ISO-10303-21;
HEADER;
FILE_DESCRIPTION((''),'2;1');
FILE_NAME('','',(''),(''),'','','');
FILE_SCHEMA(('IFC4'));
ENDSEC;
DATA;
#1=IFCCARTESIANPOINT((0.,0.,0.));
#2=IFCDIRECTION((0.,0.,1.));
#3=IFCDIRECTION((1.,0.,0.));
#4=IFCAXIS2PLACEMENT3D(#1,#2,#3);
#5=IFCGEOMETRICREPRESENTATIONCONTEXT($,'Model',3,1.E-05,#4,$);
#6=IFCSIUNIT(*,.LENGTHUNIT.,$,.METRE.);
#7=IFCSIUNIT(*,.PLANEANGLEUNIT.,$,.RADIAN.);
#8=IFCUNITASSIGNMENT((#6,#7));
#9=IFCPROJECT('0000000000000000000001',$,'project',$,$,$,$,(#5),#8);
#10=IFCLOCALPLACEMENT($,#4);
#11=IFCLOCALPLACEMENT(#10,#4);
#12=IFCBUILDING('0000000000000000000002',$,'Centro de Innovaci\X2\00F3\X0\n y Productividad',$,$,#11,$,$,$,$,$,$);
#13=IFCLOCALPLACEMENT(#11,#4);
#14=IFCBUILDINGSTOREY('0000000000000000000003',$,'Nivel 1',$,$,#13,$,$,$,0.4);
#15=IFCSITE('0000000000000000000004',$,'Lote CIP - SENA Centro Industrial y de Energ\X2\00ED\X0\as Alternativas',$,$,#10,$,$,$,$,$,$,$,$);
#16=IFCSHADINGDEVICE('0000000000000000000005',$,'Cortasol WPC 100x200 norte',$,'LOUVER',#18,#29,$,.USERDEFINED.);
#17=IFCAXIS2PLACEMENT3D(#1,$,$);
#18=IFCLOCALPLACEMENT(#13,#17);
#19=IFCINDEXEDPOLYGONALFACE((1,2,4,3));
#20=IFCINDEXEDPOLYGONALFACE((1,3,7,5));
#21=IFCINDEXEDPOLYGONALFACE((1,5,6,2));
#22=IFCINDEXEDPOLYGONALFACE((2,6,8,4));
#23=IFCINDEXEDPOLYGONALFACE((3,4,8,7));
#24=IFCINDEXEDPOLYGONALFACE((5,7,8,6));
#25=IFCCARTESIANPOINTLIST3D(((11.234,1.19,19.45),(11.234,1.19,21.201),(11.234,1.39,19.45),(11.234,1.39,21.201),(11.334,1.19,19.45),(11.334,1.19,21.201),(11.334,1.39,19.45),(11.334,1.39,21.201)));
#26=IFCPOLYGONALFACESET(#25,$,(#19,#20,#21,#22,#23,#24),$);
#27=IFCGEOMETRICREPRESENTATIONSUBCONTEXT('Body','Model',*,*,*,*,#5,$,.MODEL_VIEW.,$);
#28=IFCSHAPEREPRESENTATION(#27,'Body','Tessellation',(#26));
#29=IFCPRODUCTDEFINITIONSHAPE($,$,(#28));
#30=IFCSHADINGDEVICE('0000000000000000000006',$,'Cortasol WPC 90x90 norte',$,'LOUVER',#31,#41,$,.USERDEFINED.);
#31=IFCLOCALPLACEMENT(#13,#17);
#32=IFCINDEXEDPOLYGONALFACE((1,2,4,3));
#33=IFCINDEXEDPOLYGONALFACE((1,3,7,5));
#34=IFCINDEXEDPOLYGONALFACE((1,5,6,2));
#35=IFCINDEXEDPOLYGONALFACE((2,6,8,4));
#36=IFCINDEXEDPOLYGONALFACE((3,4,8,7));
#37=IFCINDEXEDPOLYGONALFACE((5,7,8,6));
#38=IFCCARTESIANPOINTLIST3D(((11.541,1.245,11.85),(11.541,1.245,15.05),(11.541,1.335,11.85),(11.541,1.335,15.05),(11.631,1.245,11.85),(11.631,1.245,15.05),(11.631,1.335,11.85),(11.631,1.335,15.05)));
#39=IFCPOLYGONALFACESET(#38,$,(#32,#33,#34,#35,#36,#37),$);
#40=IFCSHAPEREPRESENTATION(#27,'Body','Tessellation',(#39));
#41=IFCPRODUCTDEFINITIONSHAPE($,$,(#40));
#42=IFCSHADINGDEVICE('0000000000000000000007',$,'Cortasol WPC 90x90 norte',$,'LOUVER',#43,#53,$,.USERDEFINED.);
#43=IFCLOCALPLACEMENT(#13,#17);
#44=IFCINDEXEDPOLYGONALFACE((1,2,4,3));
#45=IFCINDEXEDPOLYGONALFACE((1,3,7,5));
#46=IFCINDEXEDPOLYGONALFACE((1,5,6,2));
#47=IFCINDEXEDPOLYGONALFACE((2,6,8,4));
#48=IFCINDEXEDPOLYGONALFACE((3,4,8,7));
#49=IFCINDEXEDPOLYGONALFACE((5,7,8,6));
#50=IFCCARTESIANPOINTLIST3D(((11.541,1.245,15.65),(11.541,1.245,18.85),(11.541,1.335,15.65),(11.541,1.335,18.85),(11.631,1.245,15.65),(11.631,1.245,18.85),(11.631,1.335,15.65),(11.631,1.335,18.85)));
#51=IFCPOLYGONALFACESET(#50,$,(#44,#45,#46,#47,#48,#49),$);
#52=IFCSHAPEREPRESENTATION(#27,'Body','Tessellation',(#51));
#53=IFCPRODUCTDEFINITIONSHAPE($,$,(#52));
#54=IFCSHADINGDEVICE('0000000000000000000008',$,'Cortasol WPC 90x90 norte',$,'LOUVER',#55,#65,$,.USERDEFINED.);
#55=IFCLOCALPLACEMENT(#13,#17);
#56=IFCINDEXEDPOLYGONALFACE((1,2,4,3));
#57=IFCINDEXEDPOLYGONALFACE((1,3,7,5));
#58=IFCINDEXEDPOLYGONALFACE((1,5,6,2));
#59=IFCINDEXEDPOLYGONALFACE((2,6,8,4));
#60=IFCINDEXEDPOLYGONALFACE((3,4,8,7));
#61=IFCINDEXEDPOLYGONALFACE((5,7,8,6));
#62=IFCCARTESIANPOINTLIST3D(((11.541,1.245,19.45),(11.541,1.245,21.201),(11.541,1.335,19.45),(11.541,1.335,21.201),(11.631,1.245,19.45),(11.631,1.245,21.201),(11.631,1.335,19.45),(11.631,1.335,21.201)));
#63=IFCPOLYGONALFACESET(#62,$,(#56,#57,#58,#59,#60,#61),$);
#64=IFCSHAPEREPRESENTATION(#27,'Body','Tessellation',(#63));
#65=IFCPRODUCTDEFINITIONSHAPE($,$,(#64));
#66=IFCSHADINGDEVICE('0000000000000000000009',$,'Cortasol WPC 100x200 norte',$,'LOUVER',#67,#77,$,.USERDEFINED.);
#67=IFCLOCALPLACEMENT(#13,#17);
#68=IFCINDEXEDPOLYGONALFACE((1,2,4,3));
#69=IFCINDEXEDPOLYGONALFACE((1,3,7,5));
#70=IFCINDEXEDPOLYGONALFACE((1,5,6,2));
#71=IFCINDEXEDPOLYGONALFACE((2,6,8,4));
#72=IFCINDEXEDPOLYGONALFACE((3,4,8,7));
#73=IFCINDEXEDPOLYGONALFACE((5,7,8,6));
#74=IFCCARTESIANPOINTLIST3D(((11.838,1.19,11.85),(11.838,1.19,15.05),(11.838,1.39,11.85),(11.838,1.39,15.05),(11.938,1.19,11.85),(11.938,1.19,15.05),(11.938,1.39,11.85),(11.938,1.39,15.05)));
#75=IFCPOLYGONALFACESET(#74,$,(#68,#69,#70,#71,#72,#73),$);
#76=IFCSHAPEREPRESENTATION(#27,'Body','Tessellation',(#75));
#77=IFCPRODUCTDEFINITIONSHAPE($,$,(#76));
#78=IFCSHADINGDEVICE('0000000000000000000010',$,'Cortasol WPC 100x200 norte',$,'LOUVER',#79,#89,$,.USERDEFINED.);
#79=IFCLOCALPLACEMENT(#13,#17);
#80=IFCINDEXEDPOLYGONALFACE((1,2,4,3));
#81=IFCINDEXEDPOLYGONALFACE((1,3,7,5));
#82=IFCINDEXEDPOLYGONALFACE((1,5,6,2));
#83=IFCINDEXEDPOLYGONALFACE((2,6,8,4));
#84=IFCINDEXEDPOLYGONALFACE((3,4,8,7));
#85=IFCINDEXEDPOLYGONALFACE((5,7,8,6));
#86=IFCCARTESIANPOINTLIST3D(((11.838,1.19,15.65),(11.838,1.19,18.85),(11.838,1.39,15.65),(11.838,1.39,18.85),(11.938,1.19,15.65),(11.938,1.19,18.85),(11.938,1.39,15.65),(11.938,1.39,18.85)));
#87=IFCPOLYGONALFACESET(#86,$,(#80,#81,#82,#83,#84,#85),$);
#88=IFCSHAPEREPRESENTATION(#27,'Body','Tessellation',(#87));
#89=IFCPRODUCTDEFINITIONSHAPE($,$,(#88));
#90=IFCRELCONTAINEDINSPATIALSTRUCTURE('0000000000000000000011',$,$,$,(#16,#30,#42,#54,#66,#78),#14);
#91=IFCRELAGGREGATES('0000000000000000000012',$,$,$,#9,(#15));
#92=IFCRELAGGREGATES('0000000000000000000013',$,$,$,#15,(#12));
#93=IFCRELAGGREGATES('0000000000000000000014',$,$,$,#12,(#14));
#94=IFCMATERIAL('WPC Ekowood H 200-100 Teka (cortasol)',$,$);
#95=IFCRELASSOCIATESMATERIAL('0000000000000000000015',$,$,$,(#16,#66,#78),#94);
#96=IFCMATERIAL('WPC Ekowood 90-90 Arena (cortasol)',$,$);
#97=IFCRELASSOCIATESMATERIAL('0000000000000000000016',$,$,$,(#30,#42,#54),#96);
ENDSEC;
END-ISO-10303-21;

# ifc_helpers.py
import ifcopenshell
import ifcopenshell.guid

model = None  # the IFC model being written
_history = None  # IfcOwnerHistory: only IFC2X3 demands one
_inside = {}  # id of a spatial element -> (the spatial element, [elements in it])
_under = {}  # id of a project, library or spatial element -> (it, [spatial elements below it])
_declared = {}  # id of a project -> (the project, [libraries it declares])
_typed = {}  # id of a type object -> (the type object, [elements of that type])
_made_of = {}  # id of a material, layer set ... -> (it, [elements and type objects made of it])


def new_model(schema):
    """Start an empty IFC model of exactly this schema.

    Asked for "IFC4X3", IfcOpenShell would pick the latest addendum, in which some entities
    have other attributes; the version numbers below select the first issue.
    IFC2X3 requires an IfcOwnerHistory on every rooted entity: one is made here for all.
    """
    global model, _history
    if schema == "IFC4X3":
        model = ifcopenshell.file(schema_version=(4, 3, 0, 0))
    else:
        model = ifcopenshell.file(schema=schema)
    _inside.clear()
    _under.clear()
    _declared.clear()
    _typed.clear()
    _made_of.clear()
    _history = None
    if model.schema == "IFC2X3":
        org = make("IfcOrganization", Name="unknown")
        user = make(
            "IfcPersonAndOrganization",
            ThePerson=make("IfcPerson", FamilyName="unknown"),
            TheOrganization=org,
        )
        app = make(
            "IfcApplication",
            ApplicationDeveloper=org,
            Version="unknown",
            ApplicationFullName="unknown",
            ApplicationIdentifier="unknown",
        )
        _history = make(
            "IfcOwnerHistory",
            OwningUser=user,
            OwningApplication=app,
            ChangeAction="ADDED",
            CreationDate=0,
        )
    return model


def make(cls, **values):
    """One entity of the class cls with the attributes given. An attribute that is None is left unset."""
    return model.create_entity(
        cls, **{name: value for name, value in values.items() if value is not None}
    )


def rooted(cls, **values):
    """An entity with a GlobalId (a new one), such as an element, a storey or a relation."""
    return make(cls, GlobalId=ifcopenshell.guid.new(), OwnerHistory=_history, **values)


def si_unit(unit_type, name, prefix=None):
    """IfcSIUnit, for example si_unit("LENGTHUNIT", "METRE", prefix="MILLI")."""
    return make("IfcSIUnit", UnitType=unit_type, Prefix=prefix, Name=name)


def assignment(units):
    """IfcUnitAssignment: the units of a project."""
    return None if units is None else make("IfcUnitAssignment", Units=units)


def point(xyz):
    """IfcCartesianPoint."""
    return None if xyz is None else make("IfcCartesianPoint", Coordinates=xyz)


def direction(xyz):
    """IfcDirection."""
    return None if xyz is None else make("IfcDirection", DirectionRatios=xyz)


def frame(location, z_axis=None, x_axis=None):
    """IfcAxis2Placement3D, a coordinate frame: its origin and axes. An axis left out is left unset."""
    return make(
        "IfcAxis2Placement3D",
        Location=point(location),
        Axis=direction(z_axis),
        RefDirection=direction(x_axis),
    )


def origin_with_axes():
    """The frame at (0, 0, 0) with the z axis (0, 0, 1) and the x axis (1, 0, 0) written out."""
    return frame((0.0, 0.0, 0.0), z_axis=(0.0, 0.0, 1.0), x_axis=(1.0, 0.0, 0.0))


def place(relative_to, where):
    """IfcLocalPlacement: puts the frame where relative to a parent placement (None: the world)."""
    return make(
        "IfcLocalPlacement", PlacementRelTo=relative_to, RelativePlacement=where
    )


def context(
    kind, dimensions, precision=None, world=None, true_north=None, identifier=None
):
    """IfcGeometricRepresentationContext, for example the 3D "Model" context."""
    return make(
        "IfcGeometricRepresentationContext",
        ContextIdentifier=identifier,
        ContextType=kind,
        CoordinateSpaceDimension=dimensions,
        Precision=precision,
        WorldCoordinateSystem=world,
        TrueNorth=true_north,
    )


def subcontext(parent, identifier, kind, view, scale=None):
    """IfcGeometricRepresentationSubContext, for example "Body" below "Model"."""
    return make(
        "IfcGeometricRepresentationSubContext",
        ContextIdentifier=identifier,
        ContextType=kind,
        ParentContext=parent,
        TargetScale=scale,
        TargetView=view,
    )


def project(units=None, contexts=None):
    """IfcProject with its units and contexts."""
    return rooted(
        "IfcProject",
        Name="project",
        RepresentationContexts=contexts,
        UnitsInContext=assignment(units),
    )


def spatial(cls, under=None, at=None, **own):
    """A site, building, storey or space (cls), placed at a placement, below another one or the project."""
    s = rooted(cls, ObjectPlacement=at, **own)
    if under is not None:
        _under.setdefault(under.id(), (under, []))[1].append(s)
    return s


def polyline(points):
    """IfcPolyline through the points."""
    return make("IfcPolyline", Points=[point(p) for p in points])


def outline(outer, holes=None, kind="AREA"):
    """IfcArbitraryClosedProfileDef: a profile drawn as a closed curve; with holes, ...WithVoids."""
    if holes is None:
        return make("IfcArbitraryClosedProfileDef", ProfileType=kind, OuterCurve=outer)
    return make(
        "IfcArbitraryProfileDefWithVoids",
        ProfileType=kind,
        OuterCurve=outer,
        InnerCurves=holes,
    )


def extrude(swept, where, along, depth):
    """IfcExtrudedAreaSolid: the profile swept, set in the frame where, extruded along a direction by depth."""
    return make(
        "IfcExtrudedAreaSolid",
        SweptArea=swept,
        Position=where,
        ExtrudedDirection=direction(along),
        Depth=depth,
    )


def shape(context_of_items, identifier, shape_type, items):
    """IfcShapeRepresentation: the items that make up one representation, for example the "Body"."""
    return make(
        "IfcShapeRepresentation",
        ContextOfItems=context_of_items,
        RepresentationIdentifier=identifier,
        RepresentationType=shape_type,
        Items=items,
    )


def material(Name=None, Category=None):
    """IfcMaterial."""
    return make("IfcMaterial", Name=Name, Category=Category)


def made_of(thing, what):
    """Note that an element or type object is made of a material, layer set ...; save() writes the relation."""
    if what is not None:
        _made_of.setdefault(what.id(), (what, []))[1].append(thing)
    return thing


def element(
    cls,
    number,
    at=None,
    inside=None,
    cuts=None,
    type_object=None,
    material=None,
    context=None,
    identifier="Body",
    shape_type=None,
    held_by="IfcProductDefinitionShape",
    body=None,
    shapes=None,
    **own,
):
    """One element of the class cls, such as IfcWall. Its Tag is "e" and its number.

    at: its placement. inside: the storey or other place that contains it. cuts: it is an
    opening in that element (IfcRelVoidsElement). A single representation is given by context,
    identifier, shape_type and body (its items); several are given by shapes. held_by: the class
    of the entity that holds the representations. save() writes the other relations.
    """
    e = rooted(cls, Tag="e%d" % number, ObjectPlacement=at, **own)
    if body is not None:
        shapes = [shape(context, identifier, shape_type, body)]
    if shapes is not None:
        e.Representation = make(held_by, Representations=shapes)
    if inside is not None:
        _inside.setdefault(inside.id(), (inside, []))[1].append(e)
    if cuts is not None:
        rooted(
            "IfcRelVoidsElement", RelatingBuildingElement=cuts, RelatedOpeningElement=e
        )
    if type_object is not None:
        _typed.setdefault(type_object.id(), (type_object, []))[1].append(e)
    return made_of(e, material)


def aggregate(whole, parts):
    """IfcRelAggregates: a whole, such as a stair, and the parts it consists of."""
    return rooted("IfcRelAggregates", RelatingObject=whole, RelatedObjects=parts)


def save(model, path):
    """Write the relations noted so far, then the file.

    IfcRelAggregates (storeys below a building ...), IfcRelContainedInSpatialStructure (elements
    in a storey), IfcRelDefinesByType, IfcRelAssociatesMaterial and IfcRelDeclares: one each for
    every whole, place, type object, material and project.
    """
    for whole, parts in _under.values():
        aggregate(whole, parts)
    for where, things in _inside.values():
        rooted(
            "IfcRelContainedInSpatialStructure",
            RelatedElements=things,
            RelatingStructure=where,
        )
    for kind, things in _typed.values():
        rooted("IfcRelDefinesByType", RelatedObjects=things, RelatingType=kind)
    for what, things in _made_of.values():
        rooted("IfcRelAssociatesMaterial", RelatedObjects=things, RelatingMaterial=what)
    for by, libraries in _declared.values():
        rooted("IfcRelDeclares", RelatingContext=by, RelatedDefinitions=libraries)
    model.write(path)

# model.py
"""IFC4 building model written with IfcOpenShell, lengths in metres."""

from ifc_helpers import new_model, si_unit, frame, origin_with_axes, place, context, subcontext, project, spatial, polyline, outline, extrude, material, element, save


model = new_model("IFC4")

# Units and contexts
model_context = context("Model", 3, precision=1e-05, world=origin_with_axes())
body_context = subcontext(model_context, "Body", "Model", "MODEL_VIEW")
ifc_project = project(units=[si_unit("LENGTHUNIT", "METRE"), si_unit("PLANEANGLEUNIT", "RADIAN")], contexts=[model_context])

# Site, building, storey
site_placement = place(None, origin_with_axes())
site = spatial("IfcSite", under=ifc_project, at=site_placement, Name="Lote CIP - SENA Centro Industrial y de Energías Alternativas")
building_placement = place(site_placement, origin_with_axes())
building = spatial("IfcBuilding", under=site, at=building_placement, Name="Centro de Innovación y Productividad")
storey_placement = place(building_placement, origin_with_axes())
storey = spatial("IfcBuildingStorey", under=building, at=storey_placement, Name="Nivel 1", Elevation=0.4)

# Shading devices
ifc_material_1 = material(Name="WPC Ekowood 90-90 Arena (cortasol)")
ifc_material_2 = material(Name="WPC Ekowood H 200-100 Teka (cortasol)")
shading_device_1_placement = place(storey_placement, origin_with_axes())
element("IfcShadingDevice", 1, at=shading_device_1_placement, inside=storey, material=ifc_material_2, Name="Cortasol WPC 100x200 norte", ObjectType="LOUVER", PredefinedType="USERDEFINED", context=body_context, shape_type="SweptSolid", body=[
    extrude(outline(polyline([(11.234, 1.19), (11.234, 1.39), (11.334, 1.39), (11.334, 1.19), (11.234, 1.19)])), frame((0.0, 0.0, 19.45)), (0.0, 0.0, 1.0), 1.751),
])
shading_device_2_placement = place(storey_placement, origin_with_axes())
element("IfcShadingDevice", 2, at=shading_device_2_placement, inside=storey, material=ifc_material_1, Name="Cortasol WPC 90x90 norte", ObjectType="LOUVER", PredefinedType="USERDEFINED", context=body_context, shape_type="SweptSolid", body=[
    extrude(outline(polyline([(11.541, 1.245), (11.541, 1.335), (11.631, 1.335), (11.631, 1.245), (11.541, 1.245)])), frame((0.0, 0.0, 11.85)), (0.0, 0.0, 1.0), 3.2),
])
shading_device_3_placement = place(storey_placement, origin_with_axes())
element("IfcShadingDevice", 3, at=shading_device_3_placement, inside=storey, material=ifc_material_1, Name="Cortasol WPC 90x90 norte", ObjectType="LOUVER", PredefinedType="USERDEFINED", context=body_context, shape_type="SweptSolid", body=[
    extrude(outline(polyline([(11.541, 1.245), (11.541, 1.335), (11.631, 1.335), (11.631, 1.245), (11.541, 1.245)])), frame((0.0, 0.0, 15.65)), (0.0, 0.0, 1.0), 3.2),
])
shading_device_4_placement = place(storey_placement, origin_with_axes())
element("IfcShadingDevice", 4, at=shading_device_4_placement, inside=storey, material=ifc_material_1, Name="Cortasol WPC 90x90 norte", ObjectType="LOUVER", PredefinedType="USERDEFINED", context=body_context, shape_type="SweptSolid", body=[
    extrude(outline(polyline([(11.541, 1.245), (11.541, 1.335), (11.631, 1.335), (11.631, 1.245), (11.541, 1.245)])), frame((0.0, 0.0, 19.45)), (0.0, 0.0, 1.0), 1.751),
])
shading_device_5_placement = place(storey_placement, origin_with_axes())
element("IfcShadingDevice", 5, at=shading_device_5_placement, inside=storey, material=ifc_material_2, Name="Cortasol WPC 100x200 norte", ObjectType="LOUVER", PredefinedType="USERDEFINED", context=body_context, shape_type="SweptSolid", body=[
    extrude(outline(polyline([(11.838, 1.19), (11.838, 1.39), (11.938, 1.39), (11.938, 1.19), (11.838, 1.19)])), frame((0.0, 0.0, 11.85)), (0.0, 0.0, 1.0), 3.2),
])
shading_device_6_placement = place(storey_placement, origin_with_axes())
element("IfcShadingDevice", 6, at=shading_device_6_placement, inside=storey, material=ifc_material_2, Name="Cortasol WPC 100x200 norte", ObjectType="LOUVER", PredefinedType="USERDEFINED", context=body_context, shape_type="SweptSolid", body=[
    extrude(outline(polyline([(11.838, 1.19), (11.838, 1.39), (11.938, 1.39), (11.938, 1.19), (11.838, 1.19)])), frame((0.0, 0.0, 15.65)), (0.0, 0.0, 1.0), 3.2),
])

save(model, "model.ifc")
